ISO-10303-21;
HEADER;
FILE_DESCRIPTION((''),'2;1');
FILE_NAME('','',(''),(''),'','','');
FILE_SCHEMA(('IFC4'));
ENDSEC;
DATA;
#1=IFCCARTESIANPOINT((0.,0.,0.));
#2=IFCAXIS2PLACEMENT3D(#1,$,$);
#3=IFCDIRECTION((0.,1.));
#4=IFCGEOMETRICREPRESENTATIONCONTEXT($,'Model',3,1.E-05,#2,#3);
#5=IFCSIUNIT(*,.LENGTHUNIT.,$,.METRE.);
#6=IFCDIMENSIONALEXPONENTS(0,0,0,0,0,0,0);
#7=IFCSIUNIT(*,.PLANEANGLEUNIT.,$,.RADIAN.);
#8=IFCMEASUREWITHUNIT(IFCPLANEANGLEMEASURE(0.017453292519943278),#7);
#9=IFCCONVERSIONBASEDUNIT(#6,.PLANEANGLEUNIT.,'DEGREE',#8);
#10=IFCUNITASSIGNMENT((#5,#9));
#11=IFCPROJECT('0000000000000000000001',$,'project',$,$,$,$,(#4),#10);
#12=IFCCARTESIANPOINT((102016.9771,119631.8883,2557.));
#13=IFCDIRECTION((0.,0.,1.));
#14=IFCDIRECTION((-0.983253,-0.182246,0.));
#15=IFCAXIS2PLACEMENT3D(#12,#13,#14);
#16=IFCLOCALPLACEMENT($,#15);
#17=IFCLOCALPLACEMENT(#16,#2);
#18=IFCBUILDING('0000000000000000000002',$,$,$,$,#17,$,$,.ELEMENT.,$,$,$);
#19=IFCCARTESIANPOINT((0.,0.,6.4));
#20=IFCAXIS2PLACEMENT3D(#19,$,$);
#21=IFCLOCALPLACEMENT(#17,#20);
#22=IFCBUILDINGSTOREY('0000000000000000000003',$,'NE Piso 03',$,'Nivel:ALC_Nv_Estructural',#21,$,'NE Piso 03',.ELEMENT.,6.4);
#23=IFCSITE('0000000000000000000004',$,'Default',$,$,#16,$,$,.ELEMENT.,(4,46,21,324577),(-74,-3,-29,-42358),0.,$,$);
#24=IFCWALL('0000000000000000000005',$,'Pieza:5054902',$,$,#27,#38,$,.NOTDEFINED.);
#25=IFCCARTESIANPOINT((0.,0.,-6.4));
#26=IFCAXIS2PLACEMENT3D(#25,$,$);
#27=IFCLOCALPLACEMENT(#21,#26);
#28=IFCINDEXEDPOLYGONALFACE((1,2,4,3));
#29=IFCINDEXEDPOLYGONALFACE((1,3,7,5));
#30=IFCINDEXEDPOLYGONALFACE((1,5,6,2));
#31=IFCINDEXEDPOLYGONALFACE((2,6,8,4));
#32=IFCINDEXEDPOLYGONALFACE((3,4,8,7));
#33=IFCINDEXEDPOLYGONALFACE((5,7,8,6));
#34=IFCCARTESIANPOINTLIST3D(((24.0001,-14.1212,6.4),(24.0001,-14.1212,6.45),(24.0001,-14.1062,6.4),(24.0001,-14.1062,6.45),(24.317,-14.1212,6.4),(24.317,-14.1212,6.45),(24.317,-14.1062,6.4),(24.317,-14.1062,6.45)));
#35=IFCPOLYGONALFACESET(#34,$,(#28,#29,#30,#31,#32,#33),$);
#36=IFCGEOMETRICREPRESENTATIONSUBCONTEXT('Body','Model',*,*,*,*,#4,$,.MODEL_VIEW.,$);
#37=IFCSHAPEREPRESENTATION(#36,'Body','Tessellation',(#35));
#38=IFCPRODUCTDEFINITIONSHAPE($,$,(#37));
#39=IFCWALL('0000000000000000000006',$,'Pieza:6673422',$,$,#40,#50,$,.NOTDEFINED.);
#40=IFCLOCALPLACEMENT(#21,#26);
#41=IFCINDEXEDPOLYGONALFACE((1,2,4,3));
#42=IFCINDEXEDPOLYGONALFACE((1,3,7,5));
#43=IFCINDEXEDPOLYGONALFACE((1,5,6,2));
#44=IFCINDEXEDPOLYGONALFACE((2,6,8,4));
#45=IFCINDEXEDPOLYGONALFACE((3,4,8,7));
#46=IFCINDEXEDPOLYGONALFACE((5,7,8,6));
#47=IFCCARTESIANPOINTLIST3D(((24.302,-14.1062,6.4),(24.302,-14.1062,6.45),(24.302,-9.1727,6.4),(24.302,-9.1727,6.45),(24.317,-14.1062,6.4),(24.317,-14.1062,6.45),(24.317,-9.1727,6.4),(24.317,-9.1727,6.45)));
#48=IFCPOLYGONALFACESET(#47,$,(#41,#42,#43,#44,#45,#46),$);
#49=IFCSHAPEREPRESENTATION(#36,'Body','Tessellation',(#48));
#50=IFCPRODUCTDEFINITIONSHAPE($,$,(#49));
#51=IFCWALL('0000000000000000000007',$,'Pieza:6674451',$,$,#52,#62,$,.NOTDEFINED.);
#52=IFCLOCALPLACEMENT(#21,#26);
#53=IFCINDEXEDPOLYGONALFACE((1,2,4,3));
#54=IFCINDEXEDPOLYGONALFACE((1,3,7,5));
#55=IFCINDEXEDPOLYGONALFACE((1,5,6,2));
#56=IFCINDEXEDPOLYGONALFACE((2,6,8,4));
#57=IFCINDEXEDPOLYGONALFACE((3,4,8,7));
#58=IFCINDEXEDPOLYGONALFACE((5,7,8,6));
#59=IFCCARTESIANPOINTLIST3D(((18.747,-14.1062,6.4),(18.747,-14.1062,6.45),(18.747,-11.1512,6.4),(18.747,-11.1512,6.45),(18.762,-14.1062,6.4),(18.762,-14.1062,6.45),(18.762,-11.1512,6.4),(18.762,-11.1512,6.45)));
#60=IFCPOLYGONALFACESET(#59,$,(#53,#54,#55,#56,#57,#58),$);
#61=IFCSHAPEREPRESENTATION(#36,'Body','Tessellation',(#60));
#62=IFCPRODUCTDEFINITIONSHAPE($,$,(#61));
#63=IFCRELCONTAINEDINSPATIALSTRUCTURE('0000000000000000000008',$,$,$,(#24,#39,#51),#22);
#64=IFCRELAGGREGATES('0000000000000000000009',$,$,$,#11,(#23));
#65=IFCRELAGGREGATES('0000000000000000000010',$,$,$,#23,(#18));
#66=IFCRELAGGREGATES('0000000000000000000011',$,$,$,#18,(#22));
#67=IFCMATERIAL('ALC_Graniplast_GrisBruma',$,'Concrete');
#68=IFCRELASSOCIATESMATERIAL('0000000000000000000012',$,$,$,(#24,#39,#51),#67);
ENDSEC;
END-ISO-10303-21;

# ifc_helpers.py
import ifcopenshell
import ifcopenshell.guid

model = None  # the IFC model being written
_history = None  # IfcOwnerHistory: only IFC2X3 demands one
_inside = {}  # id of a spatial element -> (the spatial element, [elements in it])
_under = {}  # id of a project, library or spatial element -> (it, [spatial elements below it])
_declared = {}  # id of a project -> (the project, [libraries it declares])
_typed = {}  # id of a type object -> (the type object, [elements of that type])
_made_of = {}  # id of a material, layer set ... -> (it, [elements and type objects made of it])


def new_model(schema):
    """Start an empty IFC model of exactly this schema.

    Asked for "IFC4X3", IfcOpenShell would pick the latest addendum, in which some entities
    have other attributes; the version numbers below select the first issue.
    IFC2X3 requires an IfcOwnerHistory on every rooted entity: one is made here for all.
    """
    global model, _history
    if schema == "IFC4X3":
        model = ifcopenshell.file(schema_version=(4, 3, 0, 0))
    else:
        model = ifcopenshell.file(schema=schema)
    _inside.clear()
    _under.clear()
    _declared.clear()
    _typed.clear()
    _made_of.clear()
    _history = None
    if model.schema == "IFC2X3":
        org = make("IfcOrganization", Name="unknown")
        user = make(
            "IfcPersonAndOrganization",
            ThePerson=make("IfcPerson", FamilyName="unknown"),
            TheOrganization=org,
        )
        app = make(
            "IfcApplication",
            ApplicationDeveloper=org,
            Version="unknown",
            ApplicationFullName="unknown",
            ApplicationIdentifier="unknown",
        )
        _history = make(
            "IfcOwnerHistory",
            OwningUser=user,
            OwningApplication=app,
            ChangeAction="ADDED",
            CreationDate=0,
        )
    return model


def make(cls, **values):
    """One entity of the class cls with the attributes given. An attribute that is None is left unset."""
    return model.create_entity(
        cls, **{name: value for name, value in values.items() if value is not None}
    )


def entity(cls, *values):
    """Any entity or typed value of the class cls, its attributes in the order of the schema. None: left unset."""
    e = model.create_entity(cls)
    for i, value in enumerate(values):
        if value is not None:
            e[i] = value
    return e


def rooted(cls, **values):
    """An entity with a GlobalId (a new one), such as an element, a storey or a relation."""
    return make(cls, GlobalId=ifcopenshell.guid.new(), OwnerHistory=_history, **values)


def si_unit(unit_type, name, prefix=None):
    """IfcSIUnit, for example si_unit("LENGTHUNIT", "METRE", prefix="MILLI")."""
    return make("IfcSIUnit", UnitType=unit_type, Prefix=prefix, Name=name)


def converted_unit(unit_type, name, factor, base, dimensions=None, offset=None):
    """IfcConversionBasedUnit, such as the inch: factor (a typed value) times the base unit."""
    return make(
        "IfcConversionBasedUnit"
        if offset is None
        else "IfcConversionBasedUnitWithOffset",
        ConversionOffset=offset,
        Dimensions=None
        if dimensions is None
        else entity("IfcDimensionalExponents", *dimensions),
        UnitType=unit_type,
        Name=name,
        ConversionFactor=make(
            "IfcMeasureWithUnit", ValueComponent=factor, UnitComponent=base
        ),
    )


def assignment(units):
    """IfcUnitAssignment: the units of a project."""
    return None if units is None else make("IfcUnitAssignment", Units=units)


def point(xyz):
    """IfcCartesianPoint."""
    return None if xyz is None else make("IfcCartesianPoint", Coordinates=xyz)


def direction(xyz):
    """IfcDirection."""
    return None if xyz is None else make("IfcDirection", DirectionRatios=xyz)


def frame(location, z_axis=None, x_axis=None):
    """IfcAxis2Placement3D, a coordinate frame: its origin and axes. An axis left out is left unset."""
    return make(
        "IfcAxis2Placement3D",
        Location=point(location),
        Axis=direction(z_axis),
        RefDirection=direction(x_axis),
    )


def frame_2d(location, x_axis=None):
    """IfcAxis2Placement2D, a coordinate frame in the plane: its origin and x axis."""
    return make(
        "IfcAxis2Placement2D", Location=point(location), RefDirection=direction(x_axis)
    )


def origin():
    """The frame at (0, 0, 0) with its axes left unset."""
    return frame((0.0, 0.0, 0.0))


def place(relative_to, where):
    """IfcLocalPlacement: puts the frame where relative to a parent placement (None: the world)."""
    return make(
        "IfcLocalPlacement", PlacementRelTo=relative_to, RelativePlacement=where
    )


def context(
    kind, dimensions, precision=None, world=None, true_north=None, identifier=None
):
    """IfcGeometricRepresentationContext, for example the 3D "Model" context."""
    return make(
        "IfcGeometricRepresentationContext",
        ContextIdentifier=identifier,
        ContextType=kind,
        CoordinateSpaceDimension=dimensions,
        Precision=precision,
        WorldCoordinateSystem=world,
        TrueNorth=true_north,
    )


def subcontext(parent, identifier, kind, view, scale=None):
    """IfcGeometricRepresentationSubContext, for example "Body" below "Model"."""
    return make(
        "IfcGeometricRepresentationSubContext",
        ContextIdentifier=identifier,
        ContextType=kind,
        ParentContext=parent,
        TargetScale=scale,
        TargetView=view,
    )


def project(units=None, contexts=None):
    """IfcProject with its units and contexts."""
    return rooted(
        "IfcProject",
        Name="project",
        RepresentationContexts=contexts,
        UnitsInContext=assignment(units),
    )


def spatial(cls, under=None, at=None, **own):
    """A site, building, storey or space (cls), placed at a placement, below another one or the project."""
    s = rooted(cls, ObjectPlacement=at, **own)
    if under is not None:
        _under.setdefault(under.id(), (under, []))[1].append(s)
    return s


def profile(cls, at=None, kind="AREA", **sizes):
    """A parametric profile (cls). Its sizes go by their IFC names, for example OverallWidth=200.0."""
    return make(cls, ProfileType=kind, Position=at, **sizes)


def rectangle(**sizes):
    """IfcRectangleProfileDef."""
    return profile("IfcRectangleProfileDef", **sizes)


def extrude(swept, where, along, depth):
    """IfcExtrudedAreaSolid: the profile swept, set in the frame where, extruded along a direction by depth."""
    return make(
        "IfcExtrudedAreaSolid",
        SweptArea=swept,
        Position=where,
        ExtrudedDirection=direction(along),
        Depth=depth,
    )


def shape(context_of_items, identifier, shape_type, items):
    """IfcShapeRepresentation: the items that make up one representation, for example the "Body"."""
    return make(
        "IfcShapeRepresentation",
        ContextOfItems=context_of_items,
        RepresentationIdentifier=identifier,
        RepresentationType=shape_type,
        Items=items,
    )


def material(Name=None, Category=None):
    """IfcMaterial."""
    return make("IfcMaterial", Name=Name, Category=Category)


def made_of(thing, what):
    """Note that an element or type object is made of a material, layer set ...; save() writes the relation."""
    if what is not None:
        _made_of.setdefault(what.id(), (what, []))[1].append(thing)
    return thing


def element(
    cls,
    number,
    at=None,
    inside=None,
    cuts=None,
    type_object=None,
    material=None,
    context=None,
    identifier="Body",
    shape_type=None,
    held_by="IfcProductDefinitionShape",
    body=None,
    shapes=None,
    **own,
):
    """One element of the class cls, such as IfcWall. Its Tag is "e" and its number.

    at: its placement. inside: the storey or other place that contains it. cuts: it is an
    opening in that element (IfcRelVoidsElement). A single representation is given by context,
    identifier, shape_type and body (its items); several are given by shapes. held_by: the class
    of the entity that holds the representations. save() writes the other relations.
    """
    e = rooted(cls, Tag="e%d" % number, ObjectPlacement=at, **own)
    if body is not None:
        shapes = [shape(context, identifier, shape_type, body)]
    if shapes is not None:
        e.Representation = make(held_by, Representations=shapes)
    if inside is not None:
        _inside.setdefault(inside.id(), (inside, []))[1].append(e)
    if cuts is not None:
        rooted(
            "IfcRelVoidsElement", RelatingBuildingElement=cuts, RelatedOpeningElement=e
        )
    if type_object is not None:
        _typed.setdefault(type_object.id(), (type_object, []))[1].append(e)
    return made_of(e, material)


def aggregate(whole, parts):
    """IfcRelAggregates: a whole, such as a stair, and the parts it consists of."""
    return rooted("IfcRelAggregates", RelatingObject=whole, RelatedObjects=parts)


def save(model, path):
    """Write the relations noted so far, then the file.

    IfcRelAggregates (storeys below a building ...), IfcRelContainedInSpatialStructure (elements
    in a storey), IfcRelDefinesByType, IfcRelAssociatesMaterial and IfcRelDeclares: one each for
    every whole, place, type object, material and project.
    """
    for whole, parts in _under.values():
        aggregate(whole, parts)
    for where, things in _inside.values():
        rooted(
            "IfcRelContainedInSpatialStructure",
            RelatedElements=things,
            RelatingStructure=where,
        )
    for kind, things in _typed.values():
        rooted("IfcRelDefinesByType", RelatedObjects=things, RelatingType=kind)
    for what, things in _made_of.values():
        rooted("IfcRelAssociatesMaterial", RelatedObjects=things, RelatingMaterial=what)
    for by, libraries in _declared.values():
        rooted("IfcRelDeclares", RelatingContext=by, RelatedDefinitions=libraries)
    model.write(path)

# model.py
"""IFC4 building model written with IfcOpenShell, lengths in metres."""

from ifc_helpers import new_model, entity, si_unit, converted_unit, direction, frame, frame_2d, origin, place, context, subcontext, project, spatial, rectangle, extrude, material, element, save


model = new_model("IFC4")

# Units and contexts
model_context = context("Model", 3, precision=1e-05, world=origin(), true_north=direction((0.0, 1.0)))
body_context = subcontext(model_context, "Body", "Model", "MODEL_VIEW")
ifc_project = project(units=[si_unit("LENGTHUNIT", "METRE"), converted_unit("PLANEANGLEUNIT", "DEGREE", entity("IfcPlaneAngleMeasure", 0.017453292519943278), si_unit("PLANEANGLEUNIT", "RADIAN"), dimensions=[0, 0, 0, 0, 0, 0, 0])], contexts=[model_context])

# Site, building, storey
site_placement = place(None, frame((102016.9771, 119631.8883, 2557.0), z_axis=(0.0, 0.0, 1.0), x_axis=(-0.983253, -0.182246, 0.0)))
site = spatial("IfcSite", under=ifc_project, at=site_placement, Name="Default", CompositionType="ELEMENT", RefLatitude=(4, 46, 21, 324577), RefLongitude=(-74, -3, -29, -42358), RefElevation=0.0)
building_placement = place(site_placement, origin())
building = spatial("IfcBuilding", under=site, at=building_placement, CompositionType="ELEMENT")
storey_placement = place(building_placement, frame((0.0, 0.0, 6.4)))
storey = spatial("IfcBuildingStorey", under=building, at=storey_placement, Name="NE Piso 03", ObjectType="Nivel:ALC_Nv_Estructural", LongName="NE Piso 03", CompositionType="ELEMENT", Elevation=6.4)

# Walls
ifc_material_1 = material(Name="ALC_Graniplast_GrisBruma", Category="Concrete")
wall_1_placement = place(storey_placement, frame((0.0, 0.0, -6.4)))
element("IfcWall", 1, at=wall_1_placement, inside=storey, material=ifc_material_1, Name="Pieza:5054902", PredefinedType="NOTDEFINED", context=body_context, shape_type="SweptSolid", body=[
    extrude(rectangle(XDim=0.015, YDim=0.317, at=frame_2d((0.0, 0.0), x_axis=(1.0, 0.0))), frame((24.1586, -14.1137, 6.4), z_axis=(0.0, 0.0, 1.0), x_axis=(0.0, -1.0, 0.0)), (0.0, 0.0, 1.0), 0.05),
])
wall_2_placement = place(storey_placement, frame((0.0, 0.0, -6.4)))
element("IfcWall", 2, at=wall_2_placement, inside=storey, material=ifc_material_1, Name="Pieza:6673422", PredefinedType="NOTDEFINED", context=body_context, shape_type="SweptSolid", body=[
    extrude(rectangle(XDim=4.9335, YDim=0.015, at=frame_2d((0.0, 0.0), x_axis=(1.0, 0.0))), frame((24.3095, -11.6394, 6.4), z_axis=(0.0, 0.0, 1.0), x_axis=(0.0, -1.0, 0.0)), (0.0, 0.0, 1.0), 0.05),
])
wall_3_placement = place(storey_placement, frame((0.0, 0.0, -6.4)))
element("IfcWall", 3, at=wall_3_placement, inside=storey, material=ifc_material_1, Name="Pieza:6674451", PredefinedType="NOTDEFINED", context=body_context, shape_type="SweptSolid", body=[
    extrude(rectangle(XDim=2.955, YDim=0.015, at=frame_2d((0.0, 0.0), x_axis=(1.0, 0.0))), frame((18.7545, -12.6287, 6.4), z_axis=(0.0, 0.0, 1.0), x_axis=(0.0, -1.0, 0.0)), (0.0, 0.0, 1.0), 0.05),
])

save(model, "model.ifc")
